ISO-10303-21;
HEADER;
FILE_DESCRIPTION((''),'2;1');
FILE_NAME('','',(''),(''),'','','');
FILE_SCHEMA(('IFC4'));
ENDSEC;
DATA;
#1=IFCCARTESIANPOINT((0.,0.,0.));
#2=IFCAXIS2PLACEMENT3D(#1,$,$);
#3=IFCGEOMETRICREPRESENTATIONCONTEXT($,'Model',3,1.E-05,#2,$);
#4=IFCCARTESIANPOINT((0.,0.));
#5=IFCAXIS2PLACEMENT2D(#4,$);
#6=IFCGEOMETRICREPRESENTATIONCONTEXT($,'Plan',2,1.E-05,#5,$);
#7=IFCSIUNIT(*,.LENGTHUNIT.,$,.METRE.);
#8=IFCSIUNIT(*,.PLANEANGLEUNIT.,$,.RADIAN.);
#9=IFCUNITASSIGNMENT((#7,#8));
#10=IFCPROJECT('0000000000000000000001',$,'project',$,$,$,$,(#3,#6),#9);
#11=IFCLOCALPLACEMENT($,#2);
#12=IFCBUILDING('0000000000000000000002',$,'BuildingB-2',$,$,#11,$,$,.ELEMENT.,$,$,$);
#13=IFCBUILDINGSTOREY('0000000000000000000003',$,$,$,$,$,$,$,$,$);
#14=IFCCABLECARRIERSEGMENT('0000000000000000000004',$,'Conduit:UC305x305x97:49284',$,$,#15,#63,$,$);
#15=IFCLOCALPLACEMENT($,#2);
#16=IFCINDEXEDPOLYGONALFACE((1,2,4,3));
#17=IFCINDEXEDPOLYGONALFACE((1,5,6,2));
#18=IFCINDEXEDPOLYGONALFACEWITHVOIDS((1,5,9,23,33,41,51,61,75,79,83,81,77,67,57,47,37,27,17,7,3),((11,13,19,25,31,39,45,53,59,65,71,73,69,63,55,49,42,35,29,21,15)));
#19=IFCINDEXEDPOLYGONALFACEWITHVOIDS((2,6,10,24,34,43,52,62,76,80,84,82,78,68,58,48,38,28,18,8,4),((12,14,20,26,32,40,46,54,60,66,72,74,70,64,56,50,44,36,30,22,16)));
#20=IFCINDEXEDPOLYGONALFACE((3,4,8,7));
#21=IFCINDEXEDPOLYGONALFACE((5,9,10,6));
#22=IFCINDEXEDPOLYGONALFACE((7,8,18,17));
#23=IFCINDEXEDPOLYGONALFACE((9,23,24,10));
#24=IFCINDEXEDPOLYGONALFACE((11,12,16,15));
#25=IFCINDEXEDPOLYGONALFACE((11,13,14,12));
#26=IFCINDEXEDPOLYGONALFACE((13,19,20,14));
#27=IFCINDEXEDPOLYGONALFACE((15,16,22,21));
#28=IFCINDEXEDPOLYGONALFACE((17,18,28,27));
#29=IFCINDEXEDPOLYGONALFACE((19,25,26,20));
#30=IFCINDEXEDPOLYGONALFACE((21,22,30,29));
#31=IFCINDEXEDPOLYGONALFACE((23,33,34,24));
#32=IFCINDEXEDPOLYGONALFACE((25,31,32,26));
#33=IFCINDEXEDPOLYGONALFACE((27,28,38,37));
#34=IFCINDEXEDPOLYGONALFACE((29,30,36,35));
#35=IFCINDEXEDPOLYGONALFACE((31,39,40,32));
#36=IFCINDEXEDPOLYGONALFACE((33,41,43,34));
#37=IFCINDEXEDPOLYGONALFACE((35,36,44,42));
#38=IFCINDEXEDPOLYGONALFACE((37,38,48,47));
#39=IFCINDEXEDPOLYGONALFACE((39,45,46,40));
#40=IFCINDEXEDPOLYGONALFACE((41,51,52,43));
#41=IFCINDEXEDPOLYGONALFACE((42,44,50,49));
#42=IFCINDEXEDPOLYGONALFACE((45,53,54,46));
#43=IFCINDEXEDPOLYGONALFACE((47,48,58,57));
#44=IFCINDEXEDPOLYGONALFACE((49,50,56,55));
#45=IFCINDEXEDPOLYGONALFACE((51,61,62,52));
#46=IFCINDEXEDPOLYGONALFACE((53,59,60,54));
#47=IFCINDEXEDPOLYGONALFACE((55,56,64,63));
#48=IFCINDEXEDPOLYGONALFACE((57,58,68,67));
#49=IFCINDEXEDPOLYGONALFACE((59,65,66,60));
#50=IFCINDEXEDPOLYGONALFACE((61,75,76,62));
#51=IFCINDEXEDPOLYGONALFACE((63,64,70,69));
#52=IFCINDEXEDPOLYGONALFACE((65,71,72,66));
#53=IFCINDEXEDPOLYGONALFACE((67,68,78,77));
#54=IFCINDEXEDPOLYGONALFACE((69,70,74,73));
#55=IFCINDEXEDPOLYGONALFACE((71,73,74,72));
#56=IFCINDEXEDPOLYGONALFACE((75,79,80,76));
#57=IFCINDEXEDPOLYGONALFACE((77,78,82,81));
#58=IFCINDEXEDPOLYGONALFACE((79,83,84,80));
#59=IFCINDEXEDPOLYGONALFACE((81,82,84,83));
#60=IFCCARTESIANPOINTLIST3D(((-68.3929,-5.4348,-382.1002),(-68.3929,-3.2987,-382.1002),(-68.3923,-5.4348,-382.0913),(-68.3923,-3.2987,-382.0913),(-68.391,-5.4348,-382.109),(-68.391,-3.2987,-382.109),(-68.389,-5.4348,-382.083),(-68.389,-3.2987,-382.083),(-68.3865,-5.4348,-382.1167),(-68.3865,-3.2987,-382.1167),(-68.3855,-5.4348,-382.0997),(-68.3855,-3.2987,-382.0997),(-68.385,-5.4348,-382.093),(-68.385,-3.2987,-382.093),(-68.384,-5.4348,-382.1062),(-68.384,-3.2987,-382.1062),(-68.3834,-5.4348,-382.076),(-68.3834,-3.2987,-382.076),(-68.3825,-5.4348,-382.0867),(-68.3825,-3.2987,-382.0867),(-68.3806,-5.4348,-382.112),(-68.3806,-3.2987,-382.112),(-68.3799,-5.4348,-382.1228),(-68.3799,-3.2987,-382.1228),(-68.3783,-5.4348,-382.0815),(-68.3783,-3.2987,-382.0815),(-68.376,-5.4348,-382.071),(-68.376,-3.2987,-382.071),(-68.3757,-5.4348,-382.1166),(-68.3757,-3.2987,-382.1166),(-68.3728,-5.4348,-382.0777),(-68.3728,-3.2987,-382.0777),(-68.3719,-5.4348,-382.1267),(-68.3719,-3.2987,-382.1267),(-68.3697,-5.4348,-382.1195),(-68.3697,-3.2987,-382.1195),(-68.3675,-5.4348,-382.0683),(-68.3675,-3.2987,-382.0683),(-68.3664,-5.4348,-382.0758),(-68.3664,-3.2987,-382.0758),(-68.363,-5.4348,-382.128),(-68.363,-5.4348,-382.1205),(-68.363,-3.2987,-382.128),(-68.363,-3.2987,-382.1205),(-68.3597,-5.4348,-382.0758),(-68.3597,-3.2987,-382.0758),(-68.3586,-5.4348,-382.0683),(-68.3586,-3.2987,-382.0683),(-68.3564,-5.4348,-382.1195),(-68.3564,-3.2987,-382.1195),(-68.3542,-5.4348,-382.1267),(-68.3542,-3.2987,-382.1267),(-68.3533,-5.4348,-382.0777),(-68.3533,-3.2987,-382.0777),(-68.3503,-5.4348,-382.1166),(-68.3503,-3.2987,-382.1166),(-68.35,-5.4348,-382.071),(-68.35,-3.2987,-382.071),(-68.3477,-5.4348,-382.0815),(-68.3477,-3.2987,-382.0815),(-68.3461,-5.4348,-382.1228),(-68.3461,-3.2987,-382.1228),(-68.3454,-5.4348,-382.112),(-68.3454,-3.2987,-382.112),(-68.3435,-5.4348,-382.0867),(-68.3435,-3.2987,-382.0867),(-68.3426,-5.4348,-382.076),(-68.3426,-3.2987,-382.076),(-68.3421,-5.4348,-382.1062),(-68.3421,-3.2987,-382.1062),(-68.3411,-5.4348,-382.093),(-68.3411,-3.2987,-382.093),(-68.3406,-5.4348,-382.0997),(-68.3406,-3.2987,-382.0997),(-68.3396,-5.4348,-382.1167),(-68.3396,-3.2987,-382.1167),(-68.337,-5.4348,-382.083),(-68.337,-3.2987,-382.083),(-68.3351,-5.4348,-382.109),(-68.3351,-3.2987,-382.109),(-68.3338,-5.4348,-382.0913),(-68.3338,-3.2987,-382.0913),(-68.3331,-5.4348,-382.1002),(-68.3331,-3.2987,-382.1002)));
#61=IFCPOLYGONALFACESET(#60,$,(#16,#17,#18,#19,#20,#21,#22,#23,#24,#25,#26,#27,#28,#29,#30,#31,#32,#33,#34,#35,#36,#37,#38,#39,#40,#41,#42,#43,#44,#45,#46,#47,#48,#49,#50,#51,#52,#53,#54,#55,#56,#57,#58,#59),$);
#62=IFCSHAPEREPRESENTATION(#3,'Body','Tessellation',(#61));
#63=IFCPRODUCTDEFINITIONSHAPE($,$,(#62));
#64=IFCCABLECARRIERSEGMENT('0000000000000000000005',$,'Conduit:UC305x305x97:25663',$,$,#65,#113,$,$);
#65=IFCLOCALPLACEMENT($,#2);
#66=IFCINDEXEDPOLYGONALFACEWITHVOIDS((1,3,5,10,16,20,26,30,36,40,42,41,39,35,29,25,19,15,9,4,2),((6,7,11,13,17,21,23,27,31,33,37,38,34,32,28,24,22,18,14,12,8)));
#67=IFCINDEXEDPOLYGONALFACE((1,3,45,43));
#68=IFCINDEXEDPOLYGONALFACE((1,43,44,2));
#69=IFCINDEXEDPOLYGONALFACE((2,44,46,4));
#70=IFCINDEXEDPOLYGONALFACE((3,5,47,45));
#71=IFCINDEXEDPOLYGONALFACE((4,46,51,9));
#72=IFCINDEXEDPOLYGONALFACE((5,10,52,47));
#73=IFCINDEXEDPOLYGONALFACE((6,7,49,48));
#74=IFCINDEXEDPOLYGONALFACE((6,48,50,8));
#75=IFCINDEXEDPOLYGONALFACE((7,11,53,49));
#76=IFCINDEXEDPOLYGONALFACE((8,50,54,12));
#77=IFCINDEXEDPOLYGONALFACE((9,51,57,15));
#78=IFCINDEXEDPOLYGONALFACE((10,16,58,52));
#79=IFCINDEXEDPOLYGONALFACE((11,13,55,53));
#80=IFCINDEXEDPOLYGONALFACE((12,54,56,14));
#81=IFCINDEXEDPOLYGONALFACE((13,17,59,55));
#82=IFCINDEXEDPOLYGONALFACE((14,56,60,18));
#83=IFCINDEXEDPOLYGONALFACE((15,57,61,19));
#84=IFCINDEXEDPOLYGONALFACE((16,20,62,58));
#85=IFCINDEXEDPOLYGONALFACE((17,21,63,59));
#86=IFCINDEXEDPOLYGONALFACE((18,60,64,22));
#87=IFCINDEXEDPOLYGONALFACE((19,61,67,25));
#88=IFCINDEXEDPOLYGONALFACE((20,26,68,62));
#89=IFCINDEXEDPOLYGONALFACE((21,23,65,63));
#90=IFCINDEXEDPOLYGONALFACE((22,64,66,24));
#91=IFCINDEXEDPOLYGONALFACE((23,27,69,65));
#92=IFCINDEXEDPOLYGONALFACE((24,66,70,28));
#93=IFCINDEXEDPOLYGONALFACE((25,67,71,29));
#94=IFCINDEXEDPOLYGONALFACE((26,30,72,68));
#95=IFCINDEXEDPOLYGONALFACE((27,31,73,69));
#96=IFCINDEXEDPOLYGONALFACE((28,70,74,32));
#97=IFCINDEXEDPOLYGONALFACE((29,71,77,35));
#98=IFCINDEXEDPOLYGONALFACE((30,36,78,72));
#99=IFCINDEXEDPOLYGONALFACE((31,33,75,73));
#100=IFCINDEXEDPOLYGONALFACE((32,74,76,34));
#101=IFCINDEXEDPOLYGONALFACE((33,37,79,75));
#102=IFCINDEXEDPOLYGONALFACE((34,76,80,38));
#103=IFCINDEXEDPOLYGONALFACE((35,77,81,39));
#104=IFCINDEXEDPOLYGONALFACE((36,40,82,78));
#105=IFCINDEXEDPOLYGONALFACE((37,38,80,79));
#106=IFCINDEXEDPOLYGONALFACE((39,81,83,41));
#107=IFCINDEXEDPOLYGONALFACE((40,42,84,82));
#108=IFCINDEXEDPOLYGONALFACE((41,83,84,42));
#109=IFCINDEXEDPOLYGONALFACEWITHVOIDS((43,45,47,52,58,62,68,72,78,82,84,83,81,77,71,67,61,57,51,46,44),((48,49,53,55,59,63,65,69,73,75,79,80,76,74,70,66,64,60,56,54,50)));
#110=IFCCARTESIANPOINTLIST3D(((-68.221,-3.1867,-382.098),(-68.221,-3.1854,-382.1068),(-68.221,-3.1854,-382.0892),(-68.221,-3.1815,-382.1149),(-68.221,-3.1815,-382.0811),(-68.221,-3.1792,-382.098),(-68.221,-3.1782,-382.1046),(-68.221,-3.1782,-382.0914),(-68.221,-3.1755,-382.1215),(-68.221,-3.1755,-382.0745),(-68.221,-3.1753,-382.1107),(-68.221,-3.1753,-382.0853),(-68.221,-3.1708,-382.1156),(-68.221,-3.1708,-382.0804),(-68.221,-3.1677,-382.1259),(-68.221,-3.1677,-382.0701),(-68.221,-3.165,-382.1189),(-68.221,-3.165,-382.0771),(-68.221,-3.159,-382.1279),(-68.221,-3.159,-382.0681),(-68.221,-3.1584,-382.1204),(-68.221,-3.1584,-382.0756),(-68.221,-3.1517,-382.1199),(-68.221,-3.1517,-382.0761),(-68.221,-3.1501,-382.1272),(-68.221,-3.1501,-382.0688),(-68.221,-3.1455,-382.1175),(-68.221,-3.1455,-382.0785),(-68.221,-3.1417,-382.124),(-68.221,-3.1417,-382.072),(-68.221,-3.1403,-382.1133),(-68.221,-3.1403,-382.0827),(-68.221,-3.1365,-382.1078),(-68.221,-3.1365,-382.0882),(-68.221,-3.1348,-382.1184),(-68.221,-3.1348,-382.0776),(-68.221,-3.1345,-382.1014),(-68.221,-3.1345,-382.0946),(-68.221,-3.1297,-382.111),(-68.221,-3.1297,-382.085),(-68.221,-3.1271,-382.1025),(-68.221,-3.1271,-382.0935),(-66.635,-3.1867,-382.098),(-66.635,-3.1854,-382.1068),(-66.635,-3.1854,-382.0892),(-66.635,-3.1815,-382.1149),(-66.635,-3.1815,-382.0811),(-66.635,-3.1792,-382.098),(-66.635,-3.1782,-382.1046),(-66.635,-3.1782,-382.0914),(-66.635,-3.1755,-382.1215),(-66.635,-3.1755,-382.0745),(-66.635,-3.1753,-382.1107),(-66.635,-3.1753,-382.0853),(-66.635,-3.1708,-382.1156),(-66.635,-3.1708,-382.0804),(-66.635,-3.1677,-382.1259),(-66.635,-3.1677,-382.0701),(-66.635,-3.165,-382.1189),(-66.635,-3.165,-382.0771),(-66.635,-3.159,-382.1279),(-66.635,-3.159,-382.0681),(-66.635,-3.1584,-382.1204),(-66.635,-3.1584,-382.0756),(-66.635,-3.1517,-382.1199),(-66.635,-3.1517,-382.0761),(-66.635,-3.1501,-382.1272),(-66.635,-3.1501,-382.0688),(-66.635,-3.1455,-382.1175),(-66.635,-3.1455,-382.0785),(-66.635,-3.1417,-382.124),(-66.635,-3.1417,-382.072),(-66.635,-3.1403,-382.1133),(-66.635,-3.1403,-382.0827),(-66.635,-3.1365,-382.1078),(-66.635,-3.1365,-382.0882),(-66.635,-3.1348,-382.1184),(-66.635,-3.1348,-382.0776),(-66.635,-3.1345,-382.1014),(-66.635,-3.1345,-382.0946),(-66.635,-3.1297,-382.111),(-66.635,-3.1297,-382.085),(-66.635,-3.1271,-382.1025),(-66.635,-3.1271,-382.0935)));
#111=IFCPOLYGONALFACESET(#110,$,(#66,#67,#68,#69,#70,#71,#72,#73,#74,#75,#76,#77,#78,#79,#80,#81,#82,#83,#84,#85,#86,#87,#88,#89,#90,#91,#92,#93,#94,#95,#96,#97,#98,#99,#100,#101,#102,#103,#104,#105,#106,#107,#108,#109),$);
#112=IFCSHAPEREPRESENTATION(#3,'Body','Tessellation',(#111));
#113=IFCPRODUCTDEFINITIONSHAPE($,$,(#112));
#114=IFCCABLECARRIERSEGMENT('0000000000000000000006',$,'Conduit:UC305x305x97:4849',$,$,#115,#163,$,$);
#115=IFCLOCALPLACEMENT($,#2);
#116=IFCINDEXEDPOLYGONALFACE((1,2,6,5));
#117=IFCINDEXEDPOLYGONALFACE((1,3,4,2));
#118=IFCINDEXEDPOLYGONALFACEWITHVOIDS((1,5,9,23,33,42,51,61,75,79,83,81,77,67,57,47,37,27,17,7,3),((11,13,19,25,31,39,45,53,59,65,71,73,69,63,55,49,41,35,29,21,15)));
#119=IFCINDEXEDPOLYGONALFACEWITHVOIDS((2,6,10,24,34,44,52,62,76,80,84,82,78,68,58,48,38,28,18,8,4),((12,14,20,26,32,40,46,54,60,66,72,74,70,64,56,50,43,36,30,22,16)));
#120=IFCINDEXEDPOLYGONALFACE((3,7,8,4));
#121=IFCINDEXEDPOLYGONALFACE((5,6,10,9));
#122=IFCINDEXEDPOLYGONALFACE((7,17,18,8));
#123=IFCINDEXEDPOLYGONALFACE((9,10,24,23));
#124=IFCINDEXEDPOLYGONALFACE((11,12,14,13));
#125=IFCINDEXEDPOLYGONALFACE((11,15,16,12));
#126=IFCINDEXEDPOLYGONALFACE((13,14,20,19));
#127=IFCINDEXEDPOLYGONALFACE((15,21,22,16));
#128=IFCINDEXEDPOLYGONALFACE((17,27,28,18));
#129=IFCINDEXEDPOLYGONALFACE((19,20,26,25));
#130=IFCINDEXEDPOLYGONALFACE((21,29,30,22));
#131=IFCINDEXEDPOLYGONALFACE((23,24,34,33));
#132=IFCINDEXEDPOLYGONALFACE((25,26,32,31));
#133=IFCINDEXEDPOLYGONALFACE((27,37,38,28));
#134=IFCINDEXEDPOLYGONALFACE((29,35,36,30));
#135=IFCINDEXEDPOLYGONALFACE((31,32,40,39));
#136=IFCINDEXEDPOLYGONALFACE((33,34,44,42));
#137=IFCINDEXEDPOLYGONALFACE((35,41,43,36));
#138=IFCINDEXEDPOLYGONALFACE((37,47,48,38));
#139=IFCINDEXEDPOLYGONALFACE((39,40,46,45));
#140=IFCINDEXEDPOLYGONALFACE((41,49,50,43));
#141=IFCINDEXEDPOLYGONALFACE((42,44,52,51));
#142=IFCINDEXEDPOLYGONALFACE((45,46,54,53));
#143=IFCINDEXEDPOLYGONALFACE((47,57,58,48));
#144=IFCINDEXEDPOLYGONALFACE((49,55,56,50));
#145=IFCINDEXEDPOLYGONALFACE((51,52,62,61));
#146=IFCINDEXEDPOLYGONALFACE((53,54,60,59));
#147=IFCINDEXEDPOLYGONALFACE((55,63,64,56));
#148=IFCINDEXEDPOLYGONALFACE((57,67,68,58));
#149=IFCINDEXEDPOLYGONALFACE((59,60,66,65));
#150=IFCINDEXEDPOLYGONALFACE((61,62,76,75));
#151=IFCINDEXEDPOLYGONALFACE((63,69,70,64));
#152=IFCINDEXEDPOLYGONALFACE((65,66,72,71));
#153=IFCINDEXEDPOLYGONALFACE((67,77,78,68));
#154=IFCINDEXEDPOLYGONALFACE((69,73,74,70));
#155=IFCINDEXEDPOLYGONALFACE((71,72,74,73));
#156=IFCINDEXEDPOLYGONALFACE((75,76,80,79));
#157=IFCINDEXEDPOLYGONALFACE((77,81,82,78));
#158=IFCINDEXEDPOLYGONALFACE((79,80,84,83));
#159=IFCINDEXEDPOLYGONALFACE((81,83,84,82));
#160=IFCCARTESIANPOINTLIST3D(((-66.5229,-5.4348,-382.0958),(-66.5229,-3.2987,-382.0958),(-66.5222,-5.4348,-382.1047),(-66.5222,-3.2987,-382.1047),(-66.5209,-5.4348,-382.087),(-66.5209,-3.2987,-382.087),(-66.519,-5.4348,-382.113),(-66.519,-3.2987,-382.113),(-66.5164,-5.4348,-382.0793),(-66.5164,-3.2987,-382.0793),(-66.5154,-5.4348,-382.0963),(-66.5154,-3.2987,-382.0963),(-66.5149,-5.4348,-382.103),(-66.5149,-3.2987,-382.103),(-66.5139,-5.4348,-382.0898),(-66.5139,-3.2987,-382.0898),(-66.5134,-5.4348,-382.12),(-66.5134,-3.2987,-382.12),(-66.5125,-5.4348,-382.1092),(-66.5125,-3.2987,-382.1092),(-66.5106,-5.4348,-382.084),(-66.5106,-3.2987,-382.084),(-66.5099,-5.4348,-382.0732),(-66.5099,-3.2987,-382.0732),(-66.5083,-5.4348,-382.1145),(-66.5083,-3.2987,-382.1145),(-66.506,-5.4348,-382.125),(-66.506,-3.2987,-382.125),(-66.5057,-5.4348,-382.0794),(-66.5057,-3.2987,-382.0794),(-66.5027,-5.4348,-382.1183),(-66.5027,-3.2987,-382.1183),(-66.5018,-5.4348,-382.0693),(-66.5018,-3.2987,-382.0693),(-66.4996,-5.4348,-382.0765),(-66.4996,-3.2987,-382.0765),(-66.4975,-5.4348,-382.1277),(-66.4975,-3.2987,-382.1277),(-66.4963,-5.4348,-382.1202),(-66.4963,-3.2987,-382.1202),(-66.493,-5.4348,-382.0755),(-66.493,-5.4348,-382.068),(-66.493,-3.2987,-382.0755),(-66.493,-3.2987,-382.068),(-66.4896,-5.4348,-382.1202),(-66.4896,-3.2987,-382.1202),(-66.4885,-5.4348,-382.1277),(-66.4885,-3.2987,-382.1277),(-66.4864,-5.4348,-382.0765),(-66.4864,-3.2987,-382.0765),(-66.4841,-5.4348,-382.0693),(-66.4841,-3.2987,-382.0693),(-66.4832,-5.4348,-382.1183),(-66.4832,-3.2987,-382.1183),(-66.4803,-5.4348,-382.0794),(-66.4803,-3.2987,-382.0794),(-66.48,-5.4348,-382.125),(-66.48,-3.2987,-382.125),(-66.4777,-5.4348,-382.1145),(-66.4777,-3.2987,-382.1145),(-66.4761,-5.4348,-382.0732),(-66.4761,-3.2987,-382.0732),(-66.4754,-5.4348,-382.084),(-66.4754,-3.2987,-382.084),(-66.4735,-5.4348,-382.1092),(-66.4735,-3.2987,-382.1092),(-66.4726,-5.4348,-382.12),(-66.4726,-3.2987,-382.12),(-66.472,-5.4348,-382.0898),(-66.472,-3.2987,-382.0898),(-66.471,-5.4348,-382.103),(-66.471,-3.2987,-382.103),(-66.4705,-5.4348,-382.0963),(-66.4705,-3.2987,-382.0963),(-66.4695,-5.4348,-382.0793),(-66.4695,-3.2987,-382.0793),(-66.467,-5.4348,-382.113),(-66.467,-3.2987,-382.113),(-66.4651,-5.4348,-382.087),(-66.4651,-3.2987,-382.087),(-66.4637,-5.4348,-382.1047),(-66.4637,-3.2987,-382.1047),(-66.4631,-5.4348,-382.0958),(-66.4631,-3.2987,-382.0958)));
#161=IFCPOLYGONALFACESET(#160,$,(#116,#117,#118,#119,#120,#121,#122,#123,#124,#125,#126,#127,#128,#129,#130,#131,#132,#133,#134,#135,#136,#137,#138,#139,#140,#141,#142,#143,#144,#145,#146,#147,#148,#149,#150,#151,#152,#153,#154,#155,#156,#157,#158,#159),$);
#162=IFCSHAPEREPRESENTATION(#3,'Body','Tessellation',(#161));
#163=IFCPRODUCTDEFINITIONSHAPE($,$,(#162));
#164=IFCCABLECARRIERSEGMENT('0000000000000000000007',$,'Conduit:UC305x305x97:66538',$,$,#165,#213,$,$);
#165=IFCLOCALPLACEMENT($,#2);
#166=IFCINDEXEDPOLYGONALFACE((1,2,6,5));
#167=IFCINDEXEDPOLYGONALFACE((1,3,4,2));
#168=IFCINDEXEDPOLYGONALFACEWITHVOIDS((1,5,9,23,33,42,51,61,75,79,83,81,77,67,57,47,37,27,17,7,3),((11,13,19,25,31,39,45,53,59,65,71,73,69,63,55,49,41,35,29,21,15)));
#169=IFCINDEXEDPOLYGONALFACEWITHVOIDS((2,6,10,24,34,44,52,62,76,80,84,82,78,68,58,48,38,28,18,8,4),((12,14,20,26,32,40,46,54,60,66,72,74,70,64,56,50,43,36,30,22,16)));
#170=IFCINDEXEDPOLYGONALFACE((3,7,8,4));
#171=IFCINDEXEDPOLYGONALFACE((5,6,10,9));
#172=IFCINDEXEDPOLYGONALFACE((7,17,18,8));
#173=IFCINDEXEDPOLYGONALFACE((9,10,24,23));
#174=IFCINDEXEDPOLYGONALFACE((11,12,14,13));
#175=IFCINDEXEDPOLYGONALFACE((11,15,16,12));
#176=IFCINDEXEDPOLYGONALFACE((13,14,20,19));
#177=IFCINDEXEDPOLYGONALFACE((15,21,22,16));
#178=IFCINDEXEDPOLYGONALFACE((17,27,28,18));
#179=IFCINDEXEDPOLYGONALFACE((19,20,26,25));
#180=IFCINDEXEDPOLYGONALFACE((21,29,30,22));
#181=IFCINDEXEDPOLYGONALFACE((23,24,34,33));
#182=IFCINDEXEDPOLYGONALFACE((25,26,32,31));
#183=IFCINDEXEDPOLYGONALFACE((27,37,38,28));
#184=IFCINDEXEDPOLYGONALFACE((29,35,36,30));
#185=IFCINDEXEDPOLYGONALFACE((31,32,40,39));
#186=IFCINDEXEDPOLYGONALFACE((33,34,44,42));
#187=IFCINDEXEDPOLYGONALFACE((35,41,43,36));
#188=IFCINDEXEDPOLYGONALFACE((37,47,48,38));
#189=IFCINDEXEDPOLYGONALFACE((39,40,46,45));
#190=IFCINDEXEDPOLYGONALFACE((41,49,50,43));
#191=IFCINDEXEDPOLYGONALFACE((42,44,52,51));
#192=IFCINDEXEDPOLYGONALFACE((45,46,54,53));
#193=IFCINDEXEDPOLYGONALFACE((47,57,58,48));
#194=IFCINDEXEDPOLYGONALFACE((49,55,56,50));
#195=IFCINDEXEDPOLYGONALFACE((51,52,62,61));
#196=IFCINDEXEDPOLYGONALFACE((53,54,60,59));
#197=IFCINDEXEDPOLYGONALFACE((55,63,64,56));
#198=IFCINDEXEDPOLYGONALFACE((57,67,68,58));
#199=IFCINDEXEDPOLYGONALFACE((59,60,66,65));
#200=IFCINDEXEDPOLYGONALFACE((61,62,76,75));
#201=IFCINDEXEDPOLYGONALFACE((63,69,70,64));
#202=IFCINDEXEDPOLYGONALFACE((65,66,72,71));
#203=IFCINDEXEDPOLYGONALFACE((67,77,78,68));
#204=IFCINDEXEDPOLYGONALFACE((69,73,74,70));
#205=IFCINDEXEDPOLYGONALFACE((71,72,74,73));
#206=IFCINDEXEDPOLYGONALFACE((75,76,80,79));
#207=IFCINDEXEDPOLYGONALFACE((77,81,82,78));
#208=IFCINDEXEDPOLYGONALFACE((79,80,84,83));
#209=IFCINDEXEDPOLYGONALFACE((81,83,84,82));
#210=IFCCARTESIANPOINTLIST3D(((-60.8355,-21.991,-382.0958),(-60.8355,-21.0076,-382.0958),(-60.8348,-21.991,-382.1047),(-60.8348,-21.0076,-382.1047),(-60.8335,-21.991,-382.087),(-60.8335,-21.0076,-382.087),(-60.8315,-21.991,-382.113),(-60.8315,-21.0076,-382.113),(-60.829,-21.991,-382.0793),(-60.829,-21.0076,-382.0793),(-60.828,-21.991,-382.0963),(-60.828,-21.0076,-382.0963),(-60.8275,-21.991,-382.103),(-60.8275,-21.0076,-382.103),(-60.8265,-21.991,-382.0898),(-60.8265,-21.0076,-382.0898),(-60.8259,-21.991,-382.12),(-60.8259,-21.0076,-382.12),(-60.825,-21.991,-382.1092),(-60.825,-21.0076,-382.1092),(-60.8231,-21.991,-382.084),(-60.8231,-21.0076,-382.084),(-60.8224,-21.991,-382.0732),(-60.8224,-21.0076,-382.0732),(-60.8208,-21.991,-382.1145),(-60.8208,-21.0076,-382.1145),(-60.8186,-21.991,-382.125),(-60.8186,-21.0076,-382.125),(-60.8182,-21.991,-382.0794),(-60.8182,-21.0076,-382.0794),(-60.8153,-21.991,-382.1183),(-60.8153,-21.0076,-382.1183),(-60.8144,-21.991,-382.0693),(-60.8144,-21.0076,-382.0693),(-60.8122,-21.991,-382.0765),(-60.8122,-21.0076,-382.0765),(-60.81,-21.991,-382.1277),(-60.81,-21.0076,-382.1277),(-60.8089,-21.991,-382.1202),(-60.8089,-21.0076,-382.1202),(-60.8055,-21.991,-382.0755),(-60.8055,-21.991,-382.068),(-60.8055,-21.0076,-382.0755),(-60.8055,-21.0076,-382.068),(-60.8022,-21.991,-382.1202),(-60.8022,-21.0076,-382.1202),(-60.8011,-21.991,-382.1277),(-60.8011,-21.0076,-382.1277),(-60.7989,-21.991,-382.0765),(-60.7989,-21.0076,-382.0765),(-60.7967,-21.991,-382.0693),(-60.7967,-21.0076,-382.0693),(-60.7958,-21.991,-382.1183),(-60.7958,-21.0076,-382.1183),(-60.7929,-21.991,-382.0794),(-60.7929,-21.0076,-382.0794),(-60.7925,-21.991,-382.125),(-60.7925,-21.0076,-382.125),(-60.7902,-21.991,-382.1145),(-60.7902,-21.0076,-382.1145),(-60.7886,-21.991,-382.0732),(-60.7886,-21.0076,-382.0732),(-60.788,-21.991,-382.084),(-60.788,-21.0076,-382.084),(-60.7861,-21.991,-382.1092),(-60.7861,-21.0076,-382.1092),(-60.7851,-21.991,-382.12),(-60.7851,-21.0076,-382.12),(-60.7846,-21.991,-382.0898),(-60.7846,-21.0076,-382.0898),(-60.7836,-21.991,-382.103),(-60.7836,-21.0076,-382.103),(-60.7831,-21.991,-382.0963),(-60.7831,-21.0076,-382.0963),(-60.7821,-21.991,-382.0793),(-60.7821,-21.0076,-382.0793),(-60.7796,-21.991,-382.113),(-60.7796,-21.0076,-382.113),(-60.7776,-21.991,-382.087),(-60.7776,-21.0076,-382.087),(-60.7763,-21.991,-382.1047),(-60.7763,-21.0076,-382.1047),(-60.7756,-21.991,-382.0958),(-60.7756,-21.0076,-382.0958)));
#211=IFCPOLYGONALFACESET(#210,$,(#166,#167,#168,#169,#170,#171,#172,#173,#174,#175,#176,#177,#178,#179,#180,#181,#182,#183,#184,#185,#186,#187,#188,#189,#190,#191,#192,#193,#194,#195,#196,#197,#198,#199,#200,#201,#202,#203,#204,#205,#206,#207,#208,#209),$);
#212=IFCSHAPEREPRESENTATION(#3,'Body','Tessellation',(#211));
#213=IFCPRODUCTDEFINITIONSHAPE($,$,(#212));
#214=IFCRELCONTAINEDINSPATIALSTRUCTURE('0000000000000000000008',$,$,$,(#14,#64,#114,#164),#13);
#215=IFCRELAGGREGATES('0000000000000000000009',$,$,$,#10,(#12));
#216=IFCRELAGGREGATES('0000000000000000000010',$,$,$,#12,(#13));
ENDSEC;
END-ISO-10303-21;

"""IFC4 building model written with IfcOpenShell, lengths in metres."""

from ifc_helpers import new_model, entity, si_unit, origin, origin_2d, place, context, project, spatial, element, save


model = new_model("IFC4")

# Units and contexts
model_context = context("Model", 3, precision=1e-05, world=origin())
plan_context = context("Plan", 2, precision=1e-05, world=origin_2d())
ifc_project = project(units=[si_unit("LENGTHUNIT", "METRE"), si_unit("PLANEANGLEUNIT", "RADIAN")], contexts=[model_context, plan_context])

# Building, storey
building_placement = place(None, origin())
building = spatial("IfcBuilding", under=ifc_project, at=building_placement, Name="BuildingB-2", CompositionType="ELEMENT")
storey = spatial("IfcBuildingStorey", under=building)

# Cable carrier segments
element("IfcCableCarrierSegment", 1, inside=storey, Name="Conduit:UC305x305x97:49284", context=model_context, shape_type="AdvancedSweptSolid", body=[
    entity("IfcSweptDiskSolid", entity("IfcCompositeCurve", [entity("IfcCompositeCurveSegment", "CONTINUOUS", False, entity("IfcPolyline", [entity("IfcCartesianPoint", [68.363, 5.4348, 382.098]), entity("IfcCartesianPoint", [68.363, 3.2987, 382.098])]))], False), 0.03, 0.0225),
])
element("IfcCableCarrierSegment", 2, inside=storey, Name="Conduit:UC305x305x97:25663", context=model_context, shape_type="AdvancedSweptSolid", body=[
    entity("IfcSweptDiskSolid", entity("IfcCompositeCurve", [entity("IfcCompositeCurveSegment", "CONTINUOUS", False, entity("IfcPolyline", [entity("IfcCartesianPoint", [68.221, 3.1567, 382.098]), entity("IfcCartesianPoint", [66.635, 3.1567, 382.098])]))], False), 0.03, 0.0225),
])
element("IfcCableCarrierSegment", 3, inside=storey, Name="Conduit:UC305x305x97:4849", context=model_context, shape_type="AdvancedSweptSolid", body=[
    entity("IfcSweptDiskSolid", entity("IfcCompositeCurve", [entity("IfcCompositeCurveSegment", "CONTINUOUS", False, entity("IfcPolyline", [entity("IfcCartesianPoint", [66.493, 3.2987, 382.098]), entity("IfcCartesianPoint", [66.493, 5.4348, 382.098])]))], False), 0.03, 0.0225),
])
element("IfcCableCarrierSegment", 4, inside=storey, Name="Conduit:UC305x305x97:66538", context=model_context, shape_type="AdvancedSweptSolid", body=[
    entity("IfcSweptDiskSolid", entity("IfcCompositeCurve", [entity("IfcCompositeCurveSegment", "CONTINUOUS", False, entity("IfcPolyline", [entity("IfcCartesianPoint", [60.8055, 21.0076, 382.098]), entity("IfcCartesianPoint", [60.8055, 21.991, 382.098])]))], False), 0.03, 0.0225),
])

save(model, "model.ifc")
